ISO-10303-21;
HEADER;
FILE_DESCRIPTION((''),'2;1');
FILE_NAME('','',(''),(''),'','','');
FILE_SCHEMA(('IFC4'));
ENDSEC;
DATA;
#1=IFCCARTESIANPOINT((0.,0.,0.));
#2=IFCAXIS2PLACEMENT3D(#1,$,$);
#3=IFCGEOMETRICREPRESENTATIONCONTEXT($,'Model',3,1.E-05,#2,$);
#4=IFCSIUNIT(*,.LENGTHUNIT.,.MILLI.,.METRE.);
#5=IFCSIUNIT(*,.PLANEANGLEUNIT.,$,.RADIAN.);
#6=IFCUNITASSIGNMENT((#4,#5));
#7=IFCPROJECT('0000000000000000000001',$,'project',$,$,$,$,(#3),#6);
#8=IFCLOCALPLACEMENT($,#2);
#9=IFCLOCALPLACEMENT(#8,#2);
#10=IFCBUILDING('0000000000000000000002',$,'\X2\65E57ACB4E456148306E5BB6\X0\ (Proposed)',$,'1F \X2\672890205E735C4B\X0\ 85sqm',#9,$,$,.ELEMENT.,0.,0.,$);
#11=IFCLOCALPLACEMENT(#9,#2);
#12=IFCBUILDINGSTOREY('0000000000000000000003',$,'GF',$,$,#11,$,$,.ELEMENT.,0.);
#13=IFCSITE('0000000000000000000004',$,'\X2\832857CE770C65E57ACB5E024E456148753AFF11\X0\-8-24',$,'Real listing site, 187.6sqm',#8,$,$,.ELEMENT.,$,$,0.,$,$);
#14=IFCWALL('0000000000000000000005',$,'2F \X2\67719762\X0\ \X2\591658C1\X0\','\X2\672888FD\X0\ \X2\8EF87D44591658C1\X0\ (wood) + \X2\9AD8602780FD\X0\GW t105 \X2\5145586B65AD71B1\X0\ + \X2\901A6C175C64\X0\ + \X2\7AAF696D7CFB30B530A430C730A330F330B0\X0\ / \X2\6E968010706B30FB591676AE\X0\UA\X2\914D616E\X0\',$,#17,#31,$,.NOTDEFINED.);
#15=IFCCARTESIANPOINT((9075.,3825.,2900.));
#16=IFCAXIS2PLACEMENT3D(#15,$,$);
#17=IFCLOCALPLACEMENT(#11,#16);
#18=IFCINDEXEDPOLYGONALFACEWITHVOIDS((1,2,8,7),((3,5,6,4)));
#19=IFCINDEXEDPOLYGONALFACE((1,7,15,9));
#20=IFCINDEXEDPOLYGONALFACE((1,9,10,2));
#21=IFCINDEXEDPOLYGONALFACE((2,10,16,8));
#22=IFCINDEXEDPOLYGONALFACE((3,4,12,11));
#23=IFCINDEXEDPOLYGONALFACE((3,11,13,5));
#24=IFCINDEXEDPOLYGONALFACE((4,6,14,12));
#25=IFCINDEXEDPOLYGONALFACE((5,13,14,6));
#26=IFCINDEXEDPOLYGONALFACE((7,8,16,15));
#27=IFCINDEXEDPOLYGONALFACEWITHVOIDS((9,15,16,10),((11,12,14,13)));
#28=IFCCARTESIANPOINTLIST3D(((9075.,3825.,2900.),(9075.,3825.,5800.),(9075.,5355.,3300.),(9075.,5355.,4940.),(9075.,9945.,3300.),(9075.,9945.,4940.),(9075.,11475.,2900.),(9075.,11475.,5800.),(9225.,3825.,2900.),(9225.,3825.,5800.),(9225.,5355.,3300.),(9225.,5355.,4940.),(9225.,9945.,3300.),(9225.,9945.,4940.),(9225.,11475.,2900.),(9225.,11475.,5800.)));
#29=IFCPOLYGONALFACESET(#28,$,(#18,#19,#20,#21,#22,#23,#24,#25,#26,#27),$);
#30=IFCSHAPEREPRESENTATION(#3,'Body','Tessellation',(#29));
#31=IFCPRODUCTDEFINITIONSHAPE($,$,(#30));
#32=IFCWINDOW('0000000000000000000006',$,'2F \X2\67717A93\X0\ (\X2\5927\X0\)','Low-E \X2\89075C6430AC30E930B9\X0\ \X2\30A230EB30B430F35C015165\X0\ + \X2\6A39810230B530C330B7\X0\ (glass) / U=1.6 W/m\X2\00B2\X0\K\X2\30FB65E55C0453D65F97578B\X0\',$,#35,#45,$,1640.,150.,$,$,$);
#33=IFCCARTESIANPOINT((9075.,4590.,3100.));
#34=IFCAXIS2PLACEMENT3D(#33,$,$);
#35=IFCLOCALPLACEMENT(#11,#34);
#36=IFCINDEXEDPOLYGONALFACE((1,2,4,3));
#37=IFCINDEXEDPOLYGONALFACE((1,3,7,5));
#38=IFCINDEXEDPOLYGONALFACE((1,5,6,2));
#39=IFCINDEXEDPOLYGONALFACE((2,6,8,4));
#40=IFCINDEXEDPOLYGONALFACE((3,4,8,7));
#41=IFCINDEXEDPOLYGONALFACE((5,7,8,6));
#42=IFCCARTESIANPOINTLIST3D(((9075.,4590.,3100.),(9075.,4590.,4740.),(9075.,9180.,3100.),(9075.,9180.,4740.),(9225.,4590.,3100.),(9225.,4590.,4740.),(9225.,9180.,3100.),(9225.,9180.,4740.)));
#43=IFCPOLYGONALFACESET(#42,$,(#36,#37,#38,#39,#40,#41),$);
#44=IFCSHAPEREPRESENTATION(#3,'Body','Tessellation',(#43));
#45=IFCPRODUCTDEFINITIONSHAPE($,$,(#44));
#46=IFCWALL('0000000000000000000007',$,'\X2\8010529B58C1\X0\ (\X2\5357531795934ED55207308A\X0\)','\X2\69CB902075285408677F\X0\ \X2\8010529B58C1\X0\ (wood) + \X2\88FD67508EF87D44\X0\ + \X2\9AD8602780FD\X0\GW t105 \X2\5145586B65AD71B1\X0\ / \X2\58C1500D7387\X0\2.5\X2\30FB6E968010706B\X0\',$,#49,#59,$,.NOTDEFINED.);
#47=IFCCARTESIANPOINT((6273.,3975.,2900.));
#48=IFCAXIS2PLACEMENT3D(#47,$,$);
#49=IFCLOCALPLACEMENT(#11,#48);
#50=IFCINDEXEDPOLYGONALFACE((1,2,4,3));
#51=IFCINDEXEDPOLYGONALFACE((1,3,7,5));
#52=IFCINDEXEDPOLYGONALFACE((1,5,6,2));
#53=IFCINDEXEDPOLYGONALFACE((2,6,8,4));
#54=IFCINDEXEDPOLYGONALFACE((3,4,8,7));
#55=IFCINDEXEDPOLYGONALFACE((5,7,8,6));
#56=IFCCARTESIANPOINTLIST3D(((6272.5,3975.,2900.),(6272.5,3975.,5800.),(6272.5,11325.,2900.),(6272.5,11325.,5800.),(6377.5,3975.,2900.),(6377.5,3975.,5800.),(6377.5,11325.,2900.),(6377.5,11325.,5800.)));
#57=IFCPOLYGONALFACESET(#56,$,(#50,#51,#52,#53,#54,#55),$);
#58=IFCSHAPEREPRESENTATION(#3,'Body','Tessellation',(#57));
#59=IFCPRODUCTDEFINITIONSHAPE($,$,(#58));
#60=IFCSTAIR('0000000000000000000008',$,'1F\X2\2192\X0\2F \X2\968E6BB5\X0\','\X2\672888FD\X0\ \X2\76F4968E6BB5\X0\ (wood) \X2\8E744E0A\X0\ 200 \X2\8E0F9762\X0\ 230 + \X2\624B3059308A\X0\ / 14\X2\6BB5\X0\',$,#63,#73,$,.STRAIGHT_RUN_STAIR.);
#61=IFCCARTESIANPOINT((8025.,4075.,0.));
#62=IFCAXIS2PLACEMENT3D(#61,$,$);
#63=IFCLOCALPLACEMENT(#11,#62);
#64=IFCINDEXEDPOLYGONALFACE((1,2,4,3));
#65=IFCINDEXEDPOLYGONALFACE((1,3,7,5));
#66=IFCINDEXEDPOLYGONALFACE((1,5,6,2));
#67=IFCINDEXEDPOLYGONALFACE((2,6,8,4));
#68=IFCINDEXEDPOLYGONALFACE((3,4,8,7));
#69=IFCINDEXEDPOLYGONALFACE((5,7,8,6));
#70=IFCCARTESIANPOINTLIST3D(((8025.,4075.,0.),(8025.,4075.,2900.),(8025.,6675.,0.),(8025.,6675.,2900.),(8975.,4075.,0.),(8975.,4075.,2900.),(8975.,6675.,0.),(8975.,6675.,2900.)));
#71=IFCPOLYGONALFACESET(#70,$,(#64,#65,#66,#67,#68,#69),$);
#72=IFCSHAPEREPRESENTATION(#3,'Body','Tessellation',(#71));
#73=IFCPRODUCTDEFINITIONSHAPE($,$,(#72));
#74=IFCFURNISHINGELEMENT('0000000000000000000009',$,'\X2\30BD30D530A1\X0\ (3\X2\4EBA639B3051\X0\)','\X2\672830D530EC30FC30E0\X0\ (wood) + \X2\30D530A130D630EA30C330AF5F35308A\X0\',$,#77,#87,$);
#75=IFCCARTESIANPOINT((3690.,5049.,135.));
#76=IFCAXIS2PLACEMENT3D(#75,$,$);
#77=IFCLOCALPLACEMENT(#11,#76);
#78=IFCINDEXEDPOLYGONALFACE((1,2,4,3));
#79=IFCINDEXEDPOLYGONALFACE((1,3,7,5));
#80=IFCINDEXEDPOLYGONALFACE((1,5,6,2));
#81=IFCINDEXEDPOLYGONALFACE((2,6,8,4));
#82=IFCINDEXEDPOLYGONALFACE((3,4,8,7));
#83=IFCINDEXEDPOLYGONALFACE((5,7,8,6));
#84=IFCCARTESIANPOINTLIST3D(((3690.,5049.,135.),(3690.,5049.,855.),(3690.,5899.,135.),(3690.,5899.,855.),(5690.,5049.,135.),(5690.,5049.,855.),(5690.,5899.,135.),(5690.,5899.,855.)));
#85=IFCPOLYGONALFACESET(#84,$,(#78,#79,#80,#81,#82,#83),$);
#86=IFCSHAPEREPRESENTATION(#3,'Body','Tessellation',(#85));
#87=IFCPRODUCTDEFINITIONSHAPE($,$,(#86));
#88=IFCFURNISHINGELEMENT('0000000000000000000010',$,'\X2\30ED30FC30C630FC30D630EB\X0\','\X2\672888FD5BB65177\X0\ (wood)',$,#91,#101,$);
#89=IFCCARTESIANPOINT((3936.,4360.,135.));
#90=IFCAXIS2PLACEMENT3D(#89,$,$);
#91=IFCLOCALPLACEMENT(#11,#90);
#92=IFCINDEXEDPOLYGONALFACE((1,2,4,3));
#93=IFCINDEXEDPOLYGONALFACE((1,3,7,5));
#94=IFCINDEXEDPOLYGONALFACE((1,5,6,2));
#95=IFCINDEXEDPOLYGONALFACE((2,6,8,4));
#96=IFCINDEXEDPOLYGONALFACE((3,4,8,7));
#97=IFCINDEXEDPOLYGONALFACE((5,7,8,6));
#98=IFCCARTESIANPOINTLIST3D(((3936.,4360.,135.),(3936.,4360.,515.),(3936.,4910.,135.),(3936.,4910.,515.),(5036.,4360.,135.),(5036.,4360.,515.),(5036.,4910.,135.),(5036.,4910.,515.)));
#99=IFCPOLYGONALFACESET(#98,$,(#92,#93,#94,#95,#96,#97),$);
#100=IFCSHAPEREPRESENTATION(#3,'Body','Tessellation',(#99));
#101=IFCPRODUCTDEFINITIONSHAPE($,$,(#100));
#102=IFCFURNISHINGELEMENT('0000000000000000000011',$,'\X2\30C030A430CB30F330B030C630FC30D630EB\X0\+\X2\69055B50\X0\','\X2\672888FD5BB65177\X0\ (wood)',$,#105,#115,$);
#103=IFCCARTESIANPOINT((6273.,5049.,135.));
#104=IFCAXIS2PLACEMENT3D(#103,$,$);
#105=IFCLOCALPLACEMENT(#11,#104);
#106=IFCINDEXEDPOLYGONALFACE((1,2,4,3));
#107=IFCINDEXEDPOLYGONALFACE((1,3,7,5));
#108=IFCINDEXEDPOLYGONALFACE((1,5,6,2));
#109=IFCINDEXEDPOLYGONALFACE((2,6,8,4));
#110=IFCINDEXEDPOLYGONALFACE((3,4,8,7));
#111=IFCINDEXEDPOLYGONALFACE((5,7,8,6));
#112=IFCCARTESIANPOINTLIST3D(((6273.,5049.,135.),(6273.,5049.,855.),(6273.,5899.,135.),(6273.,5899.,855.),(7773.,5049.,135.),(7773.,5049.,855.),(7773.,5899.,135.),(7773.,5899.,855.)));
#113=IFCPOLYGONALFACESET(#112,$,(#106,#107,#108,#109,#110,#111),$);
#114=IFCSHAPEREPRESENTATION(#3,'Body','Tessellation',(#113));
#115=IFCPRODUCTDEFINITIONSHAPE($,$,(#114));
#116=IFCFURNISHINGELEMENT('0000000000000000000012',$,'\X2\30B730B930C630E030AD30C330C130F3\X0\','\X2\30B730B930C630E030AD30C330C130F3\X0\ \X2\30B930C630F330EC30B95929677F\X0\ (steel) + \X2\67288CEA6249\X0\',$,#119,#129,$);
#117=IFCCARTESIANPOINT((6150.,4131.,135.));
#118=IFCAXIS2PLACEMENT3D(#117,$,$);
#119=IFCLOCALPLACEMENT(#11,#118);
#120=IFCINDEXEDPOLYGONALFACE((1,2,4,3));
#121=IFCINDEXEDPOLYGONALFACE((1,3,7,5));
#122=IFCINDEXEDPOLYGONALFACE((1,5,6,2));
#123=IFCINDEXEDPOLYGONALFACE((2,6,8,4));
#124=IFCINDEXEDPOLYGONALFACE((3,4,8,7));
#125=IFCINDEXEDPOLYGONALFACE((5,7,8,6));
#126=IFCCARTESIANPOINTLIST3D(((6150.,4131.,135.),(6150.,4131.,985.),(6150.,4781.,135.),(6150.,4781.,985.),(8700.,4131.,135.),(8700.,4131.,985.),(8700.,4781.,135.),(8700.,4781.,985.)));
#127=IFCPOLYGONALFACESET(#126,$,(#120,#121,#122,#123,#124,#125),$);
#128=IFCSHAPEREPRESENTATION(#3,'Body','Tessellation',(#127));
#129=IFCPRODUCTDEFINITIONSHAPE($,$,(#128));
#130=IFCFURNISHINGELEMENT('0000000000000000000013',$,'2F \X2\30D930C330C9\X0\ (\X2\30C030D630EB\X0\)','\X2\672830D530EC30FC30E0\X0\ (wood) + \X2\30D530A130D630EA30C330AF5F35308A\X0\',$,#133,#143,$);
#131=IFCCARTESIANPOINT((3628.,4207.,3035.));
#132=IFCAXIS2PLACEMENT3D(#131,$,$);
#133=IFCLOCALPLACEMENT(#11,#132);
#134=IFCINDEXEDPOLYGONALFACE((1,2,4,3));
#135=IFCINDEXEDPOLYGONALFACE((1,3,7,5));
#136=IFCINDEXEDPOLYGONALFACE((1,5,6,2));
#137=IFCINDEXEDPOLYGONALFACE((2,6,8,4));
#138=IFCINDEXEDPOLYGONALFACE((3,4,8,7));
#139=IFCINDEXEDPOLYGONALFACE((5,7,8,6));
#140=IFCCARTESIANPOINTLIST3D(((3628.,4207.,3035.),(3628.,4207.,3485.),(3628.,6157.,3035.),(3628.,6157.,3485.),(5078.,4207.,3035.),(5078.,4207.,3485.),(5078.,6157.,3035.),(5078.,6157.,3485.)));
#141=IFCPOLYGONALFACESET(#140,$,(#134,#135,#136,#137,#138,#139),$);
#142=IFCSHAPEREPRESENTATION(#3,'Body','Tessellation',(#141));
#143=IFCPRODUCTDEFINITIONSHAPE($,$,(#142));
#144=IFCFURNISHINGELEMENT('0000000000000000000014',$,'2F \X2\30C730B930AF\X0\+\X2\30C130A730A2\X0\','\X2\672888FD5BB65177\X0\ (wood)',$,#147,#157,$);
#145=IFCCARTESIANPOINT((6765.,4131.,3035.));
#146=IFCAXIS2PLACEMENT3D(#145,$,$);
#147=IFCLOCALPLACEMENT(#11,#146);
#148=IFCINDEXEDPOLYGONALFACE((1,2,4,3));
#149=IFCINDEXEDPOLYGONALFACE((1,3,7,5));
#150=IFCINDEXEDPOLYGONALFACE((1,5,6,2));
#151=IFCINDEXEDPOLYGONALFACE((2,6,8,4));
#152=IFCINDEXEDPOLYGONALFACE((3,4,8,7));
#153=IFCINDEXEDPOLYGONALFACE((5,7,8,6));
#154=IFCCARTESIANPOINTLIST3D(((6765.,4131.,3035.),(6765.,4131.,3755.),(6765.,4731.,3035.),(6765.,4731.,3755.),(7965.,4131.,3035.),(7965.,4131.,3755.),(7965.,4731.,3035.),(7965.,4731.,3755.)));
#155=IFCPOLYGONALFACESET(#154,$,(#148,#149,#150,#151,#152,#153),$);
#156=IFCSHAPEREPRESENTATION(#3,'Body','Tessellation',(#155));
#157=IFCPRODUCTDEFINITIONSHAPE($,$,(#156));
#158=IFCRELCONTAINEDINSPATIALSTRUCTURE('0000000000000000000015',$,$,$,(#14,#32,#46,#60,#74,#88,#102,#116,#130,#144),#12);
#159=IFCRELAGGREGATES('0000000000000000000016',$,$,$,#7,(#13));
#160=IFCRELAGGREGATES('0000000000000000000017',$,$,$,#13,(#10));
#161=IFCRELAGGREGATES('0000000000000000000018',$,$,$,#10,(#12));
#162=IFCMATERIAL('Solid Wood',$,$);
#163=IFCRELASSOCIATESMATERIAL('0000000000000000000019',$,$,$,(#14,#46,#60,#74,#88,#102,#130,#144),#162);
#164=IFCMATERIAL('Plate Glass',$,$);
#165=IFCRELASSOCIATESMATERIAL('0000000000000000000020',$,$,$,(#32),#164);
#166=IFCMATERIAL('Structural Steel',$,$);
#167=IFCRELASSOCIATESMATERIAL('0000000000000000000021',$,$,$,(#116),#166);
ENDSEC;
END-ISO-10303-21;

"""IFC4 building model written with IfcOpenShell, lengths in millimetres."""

from ifc_helpers import new_model, si_unit, frame, frame_2d, origin, place, context, project, spatial, rectangle, extrude, material, element, fill, save


model = new_model("IFC4")

# Units and contexts
model_context = context("Model", 3, precision=1e-05, world=origin())
ifc_project = project(units=[si_unit("LENGTHUNIT", "METRE", prefix="MILLI"), si_unit("PLANEANGLEUNIT", "RADIAN")], contexts=[model_context])

# Site, building, storey
site_placement = place(None, origin())
site = spatial("IfcSite", under=ifc_project, at=site_placement, Name="茨城県日立市久慈町１-8-24", ObjectType="Real listing site, 187.6sqm", CompositionType="ELEMENT", RefElevation=0.0)
building_placement = place(site_placement, origin())
building = spatial("IfcBuilding", under=site, at=building_placement, Name="日立久慈の家 (Proposed)", ObjectType="1F 木造平屋 85sqm", CompositionType="ELEMENT", ElevationOfRefHeight=0.0, ElevationOfTerrain=0.0)
storey_placement = place(building_placement, origin())
storey = spatial("IfcBuildingStorey", under=building, at=storey_placement, Name="GF", CompositionType="ELEMENT", Elevation=0.0)

# Shared definitions
ifc_material_1 = material(Name="Solid Wood")
ifc_material_2 = material(Name="Plate Glass")

# Wall, opening, window
wall_1_placement = place(storey_placement, frame((9075.0, 3825.0, 2900.0)))
wall_1 = element("IfcWall", 1, at=wall_1_placement, inside=storey, material=ifc_material_1, Name="2F 東面 外壁", Description="木製 軸組外壁 (wood) + 高性能GW t105 充填断熱 + 通気層 + 窯業系サイディング / 準耐火・外皮UA配慮", PredefinedType="NOTDEFINED", context=model_context, shape_type="SweptSolid", body=[
    extrude(rectangle(XDim=150.0, YDim=7650.0, at=frame_2d((75.0, 3825.0))), frame((9075.0, 3825.0, 2900.0)), (0.0, 0.0, 1.0), 2900.0),
])
opening_1_placement = place(storey_placement, frame((9075.0, 4590.0, 3100.0)))
opening_1 = element("IfcOpeningElement", 2, at=opening_1_placement, cuts=wall_1, PredefinedType="NOTDEFINED", context=model_context, shape_type="SweptSolid", body=[
    extrude(rectangle(XDim=150.0, YDim=4590.0, at=frame_2d((75.0, 2295.0))), frame((9075.0, 4590.0, 3100.0)), (0.0, 0.0, 1.0), 1640.0),
])
window_1_placement = place(storey_placement, frame((9075.0, 4590.0, 3100.0)))
window_1 = element("IfcWindow", 3, at=window_1_placement, inside=storey, material=ifc_material_2, Name="2F 東窓 (大)", Description="Low-E 複層ガラス アルゴン封入 + 樹脂サッシ (glass) / U=1.6 W/m²K・日射取得型", OverallHeight=1640.0, OverallWidth=150.0, context=model_context, shape_type="SweptSolid", body=[
    extrude(rectangle(XDim=150.0, YDim=4590.0, at=frame_2d((75.0, 2295.0))), frame((9075.0, 4590.0, 3100.0)), (0.0, 0.0, 1.0), 1640.0),
])
fill(opening_1, window_1)

# Wall
wall_2_placement = place(storey_placement, frame((6273.0, 3975.0, 2900.0)))
element("IfcWall", 4, at=wall_2_placement, inside=storey, material=ifc_material_1, Name="耐力壁 (南北間仕切り)", Description="構造用合板 耐力壁 (wood) + 製材軸組 + 高性能GW t105 充填断熱 / 壁倍率2.5・準耐火", PredefinedType="NOTDEFINED", context=model_context, shape_type="SweptSolid", body=[
    extrude(rectangle(XDim=105.0, YDim=7350.0, at=frame_2d((52.0, 3675.0))), frame((6273.0, 3975.0, 2900.0)), (0.0, 0.0, 1.0), 2900.0),
])

# Stair
stair_placement = place(storey_placement, frame((8025.0, 4075.0, 0.0)))
element("IfcStair", 5, at=stair_placement, inside=storey, material=ifc_material_1, Name="1F→2F 階段", Description="木製 直階段 (wood) 蹴上 200 踏面 230 + 手すり / 14段", PredefinedType="STRAIGHT_RUN_STAIR", context=model_context, shape_type="SweptSolid", body=[
    extrude(rectangle(XDim=950.0, YDim=2600.0, at=frame_2d((475.0, 1300.0))), frame((8025.0, 4075.0, 0.0)), (0.0, 0.0, 1.0), 2900.0),
])

# Furnishing elements
furnishing_1_placement = place(storey_placement, frame((3690.0, 5049.0, 135.0)))
element("IfcFurnishingElement", 6, at=furnishing_1_placement, inside=storey, material=ifc_material_1, Name="ソファ (3人掛け)", Description="木フレーム (wood) + ファブリック張り", context=model_context, shape_type="SweptSolid", body=[
    extrude(rectangle(XDim=2000.0, YDim=850.0, at=frame_2d((1000.0, 425.0))), frame((3690.0, 5049.0, 135.0)), (0.0, 0.0, 1.0), 720.0),
])
furnishing_2_placement = place(storey_placement, frame((3936.0, 4360.0, 135.0)))
element("IfcFurnishingElement", 7, at=furnishing_2_placement, inside=storey, material=ifc_material_1, Name="ローテーブル", Description="木製家具 (wood)", context=model_context, shape_type="SweptSolid", body=[
    extrude(rectangle(XDim=1100.0, YDim=550.0, at=frame_2d((550.0, 275.0))), frame((3936.0, 4360.0, 135.0)), (0.0, 0.0, 1.0), 380.0),
])
furnishing_3_placement = place(storey_placement, frame((6273.0, 5049.0, 135.0)))
element("IfcFurnishingElement", 8, at=furnishing_3_placement, inside=storey, material=ifc_material_1, Name="ダイニングテーブル+椅子", Description="木製家具 (wood)", context=model_context, shape_type="SweptSolid", body=[
    extrude(rectangle(XDim=1500.0, YDim=850.0, at=frame_2d((750.0, 425.0))), frame((6273.0, 5049.0, 135.0)), (0.0, 0.0, 1.0), 720.0),
])
ifc_material_3 = material(Name="Structural Steel")
furnishing_4_placement = place(storey_placement, frame((6150.0, 4131.0, 135.0)))
element("IfcFurnishingElement", 9, at=furnishing_4_placement, inside=storey, material=ifc_material_3, Name="システムキッチン", Description="システムキッチン ステンレス天板 (steel) + 木質扉", context=model_context, shape_type="SweptSolid", body=[
    extrude(rectangle(XDim=2550.0, YDim=650.0, at=frame_2d((1275.0, 325.0))), frame((6150.0, 4131.0, 135.0)), (0.0, 0.0, 1.0), 850.0),
])
furnishing_5_placement = place(storey_placement, frame((3628.0, 4207.0, 3035.0)))
element("IfcFurnishingElement", 10, at=furnishing_5_placement, inside=storey, material=ifc_material_1, Name="2F ベッド (ダブル)", Description="木フレーム (wood) + ファブリック張り", context=model_context, shape_type="SweptSolid", body=[
    extrude(rectangle(XDim=1450.0, YDim=1950.0, at=frame_2d((725.0, 975.0))), frame((3628.0, 4207.0, 3035.0)), (0.0, 0.0, 1.0), 450.0),
])
furnishing_6_placement = place(storey_placement, frame((6765.0, 4131.0, 3035.0)))
element("IfcFurnishingElement", 11, at=furnishing_6_placement, inside=storey, material=ifc_material_1, Name="2F デスク+チェア", Description="木製家具 (wood)", context=model_context, shape_type="SweptSolid", body=[
    extrude(rectangle(XDim=1200.0, YDim=600.0, at=frame_2d((600.0, 300.0))), frame((6765.0, 4131.0, 3035.0)), (0.0, 0.0, 1.0), 720.0),
])

save(model, "model.ifc")
